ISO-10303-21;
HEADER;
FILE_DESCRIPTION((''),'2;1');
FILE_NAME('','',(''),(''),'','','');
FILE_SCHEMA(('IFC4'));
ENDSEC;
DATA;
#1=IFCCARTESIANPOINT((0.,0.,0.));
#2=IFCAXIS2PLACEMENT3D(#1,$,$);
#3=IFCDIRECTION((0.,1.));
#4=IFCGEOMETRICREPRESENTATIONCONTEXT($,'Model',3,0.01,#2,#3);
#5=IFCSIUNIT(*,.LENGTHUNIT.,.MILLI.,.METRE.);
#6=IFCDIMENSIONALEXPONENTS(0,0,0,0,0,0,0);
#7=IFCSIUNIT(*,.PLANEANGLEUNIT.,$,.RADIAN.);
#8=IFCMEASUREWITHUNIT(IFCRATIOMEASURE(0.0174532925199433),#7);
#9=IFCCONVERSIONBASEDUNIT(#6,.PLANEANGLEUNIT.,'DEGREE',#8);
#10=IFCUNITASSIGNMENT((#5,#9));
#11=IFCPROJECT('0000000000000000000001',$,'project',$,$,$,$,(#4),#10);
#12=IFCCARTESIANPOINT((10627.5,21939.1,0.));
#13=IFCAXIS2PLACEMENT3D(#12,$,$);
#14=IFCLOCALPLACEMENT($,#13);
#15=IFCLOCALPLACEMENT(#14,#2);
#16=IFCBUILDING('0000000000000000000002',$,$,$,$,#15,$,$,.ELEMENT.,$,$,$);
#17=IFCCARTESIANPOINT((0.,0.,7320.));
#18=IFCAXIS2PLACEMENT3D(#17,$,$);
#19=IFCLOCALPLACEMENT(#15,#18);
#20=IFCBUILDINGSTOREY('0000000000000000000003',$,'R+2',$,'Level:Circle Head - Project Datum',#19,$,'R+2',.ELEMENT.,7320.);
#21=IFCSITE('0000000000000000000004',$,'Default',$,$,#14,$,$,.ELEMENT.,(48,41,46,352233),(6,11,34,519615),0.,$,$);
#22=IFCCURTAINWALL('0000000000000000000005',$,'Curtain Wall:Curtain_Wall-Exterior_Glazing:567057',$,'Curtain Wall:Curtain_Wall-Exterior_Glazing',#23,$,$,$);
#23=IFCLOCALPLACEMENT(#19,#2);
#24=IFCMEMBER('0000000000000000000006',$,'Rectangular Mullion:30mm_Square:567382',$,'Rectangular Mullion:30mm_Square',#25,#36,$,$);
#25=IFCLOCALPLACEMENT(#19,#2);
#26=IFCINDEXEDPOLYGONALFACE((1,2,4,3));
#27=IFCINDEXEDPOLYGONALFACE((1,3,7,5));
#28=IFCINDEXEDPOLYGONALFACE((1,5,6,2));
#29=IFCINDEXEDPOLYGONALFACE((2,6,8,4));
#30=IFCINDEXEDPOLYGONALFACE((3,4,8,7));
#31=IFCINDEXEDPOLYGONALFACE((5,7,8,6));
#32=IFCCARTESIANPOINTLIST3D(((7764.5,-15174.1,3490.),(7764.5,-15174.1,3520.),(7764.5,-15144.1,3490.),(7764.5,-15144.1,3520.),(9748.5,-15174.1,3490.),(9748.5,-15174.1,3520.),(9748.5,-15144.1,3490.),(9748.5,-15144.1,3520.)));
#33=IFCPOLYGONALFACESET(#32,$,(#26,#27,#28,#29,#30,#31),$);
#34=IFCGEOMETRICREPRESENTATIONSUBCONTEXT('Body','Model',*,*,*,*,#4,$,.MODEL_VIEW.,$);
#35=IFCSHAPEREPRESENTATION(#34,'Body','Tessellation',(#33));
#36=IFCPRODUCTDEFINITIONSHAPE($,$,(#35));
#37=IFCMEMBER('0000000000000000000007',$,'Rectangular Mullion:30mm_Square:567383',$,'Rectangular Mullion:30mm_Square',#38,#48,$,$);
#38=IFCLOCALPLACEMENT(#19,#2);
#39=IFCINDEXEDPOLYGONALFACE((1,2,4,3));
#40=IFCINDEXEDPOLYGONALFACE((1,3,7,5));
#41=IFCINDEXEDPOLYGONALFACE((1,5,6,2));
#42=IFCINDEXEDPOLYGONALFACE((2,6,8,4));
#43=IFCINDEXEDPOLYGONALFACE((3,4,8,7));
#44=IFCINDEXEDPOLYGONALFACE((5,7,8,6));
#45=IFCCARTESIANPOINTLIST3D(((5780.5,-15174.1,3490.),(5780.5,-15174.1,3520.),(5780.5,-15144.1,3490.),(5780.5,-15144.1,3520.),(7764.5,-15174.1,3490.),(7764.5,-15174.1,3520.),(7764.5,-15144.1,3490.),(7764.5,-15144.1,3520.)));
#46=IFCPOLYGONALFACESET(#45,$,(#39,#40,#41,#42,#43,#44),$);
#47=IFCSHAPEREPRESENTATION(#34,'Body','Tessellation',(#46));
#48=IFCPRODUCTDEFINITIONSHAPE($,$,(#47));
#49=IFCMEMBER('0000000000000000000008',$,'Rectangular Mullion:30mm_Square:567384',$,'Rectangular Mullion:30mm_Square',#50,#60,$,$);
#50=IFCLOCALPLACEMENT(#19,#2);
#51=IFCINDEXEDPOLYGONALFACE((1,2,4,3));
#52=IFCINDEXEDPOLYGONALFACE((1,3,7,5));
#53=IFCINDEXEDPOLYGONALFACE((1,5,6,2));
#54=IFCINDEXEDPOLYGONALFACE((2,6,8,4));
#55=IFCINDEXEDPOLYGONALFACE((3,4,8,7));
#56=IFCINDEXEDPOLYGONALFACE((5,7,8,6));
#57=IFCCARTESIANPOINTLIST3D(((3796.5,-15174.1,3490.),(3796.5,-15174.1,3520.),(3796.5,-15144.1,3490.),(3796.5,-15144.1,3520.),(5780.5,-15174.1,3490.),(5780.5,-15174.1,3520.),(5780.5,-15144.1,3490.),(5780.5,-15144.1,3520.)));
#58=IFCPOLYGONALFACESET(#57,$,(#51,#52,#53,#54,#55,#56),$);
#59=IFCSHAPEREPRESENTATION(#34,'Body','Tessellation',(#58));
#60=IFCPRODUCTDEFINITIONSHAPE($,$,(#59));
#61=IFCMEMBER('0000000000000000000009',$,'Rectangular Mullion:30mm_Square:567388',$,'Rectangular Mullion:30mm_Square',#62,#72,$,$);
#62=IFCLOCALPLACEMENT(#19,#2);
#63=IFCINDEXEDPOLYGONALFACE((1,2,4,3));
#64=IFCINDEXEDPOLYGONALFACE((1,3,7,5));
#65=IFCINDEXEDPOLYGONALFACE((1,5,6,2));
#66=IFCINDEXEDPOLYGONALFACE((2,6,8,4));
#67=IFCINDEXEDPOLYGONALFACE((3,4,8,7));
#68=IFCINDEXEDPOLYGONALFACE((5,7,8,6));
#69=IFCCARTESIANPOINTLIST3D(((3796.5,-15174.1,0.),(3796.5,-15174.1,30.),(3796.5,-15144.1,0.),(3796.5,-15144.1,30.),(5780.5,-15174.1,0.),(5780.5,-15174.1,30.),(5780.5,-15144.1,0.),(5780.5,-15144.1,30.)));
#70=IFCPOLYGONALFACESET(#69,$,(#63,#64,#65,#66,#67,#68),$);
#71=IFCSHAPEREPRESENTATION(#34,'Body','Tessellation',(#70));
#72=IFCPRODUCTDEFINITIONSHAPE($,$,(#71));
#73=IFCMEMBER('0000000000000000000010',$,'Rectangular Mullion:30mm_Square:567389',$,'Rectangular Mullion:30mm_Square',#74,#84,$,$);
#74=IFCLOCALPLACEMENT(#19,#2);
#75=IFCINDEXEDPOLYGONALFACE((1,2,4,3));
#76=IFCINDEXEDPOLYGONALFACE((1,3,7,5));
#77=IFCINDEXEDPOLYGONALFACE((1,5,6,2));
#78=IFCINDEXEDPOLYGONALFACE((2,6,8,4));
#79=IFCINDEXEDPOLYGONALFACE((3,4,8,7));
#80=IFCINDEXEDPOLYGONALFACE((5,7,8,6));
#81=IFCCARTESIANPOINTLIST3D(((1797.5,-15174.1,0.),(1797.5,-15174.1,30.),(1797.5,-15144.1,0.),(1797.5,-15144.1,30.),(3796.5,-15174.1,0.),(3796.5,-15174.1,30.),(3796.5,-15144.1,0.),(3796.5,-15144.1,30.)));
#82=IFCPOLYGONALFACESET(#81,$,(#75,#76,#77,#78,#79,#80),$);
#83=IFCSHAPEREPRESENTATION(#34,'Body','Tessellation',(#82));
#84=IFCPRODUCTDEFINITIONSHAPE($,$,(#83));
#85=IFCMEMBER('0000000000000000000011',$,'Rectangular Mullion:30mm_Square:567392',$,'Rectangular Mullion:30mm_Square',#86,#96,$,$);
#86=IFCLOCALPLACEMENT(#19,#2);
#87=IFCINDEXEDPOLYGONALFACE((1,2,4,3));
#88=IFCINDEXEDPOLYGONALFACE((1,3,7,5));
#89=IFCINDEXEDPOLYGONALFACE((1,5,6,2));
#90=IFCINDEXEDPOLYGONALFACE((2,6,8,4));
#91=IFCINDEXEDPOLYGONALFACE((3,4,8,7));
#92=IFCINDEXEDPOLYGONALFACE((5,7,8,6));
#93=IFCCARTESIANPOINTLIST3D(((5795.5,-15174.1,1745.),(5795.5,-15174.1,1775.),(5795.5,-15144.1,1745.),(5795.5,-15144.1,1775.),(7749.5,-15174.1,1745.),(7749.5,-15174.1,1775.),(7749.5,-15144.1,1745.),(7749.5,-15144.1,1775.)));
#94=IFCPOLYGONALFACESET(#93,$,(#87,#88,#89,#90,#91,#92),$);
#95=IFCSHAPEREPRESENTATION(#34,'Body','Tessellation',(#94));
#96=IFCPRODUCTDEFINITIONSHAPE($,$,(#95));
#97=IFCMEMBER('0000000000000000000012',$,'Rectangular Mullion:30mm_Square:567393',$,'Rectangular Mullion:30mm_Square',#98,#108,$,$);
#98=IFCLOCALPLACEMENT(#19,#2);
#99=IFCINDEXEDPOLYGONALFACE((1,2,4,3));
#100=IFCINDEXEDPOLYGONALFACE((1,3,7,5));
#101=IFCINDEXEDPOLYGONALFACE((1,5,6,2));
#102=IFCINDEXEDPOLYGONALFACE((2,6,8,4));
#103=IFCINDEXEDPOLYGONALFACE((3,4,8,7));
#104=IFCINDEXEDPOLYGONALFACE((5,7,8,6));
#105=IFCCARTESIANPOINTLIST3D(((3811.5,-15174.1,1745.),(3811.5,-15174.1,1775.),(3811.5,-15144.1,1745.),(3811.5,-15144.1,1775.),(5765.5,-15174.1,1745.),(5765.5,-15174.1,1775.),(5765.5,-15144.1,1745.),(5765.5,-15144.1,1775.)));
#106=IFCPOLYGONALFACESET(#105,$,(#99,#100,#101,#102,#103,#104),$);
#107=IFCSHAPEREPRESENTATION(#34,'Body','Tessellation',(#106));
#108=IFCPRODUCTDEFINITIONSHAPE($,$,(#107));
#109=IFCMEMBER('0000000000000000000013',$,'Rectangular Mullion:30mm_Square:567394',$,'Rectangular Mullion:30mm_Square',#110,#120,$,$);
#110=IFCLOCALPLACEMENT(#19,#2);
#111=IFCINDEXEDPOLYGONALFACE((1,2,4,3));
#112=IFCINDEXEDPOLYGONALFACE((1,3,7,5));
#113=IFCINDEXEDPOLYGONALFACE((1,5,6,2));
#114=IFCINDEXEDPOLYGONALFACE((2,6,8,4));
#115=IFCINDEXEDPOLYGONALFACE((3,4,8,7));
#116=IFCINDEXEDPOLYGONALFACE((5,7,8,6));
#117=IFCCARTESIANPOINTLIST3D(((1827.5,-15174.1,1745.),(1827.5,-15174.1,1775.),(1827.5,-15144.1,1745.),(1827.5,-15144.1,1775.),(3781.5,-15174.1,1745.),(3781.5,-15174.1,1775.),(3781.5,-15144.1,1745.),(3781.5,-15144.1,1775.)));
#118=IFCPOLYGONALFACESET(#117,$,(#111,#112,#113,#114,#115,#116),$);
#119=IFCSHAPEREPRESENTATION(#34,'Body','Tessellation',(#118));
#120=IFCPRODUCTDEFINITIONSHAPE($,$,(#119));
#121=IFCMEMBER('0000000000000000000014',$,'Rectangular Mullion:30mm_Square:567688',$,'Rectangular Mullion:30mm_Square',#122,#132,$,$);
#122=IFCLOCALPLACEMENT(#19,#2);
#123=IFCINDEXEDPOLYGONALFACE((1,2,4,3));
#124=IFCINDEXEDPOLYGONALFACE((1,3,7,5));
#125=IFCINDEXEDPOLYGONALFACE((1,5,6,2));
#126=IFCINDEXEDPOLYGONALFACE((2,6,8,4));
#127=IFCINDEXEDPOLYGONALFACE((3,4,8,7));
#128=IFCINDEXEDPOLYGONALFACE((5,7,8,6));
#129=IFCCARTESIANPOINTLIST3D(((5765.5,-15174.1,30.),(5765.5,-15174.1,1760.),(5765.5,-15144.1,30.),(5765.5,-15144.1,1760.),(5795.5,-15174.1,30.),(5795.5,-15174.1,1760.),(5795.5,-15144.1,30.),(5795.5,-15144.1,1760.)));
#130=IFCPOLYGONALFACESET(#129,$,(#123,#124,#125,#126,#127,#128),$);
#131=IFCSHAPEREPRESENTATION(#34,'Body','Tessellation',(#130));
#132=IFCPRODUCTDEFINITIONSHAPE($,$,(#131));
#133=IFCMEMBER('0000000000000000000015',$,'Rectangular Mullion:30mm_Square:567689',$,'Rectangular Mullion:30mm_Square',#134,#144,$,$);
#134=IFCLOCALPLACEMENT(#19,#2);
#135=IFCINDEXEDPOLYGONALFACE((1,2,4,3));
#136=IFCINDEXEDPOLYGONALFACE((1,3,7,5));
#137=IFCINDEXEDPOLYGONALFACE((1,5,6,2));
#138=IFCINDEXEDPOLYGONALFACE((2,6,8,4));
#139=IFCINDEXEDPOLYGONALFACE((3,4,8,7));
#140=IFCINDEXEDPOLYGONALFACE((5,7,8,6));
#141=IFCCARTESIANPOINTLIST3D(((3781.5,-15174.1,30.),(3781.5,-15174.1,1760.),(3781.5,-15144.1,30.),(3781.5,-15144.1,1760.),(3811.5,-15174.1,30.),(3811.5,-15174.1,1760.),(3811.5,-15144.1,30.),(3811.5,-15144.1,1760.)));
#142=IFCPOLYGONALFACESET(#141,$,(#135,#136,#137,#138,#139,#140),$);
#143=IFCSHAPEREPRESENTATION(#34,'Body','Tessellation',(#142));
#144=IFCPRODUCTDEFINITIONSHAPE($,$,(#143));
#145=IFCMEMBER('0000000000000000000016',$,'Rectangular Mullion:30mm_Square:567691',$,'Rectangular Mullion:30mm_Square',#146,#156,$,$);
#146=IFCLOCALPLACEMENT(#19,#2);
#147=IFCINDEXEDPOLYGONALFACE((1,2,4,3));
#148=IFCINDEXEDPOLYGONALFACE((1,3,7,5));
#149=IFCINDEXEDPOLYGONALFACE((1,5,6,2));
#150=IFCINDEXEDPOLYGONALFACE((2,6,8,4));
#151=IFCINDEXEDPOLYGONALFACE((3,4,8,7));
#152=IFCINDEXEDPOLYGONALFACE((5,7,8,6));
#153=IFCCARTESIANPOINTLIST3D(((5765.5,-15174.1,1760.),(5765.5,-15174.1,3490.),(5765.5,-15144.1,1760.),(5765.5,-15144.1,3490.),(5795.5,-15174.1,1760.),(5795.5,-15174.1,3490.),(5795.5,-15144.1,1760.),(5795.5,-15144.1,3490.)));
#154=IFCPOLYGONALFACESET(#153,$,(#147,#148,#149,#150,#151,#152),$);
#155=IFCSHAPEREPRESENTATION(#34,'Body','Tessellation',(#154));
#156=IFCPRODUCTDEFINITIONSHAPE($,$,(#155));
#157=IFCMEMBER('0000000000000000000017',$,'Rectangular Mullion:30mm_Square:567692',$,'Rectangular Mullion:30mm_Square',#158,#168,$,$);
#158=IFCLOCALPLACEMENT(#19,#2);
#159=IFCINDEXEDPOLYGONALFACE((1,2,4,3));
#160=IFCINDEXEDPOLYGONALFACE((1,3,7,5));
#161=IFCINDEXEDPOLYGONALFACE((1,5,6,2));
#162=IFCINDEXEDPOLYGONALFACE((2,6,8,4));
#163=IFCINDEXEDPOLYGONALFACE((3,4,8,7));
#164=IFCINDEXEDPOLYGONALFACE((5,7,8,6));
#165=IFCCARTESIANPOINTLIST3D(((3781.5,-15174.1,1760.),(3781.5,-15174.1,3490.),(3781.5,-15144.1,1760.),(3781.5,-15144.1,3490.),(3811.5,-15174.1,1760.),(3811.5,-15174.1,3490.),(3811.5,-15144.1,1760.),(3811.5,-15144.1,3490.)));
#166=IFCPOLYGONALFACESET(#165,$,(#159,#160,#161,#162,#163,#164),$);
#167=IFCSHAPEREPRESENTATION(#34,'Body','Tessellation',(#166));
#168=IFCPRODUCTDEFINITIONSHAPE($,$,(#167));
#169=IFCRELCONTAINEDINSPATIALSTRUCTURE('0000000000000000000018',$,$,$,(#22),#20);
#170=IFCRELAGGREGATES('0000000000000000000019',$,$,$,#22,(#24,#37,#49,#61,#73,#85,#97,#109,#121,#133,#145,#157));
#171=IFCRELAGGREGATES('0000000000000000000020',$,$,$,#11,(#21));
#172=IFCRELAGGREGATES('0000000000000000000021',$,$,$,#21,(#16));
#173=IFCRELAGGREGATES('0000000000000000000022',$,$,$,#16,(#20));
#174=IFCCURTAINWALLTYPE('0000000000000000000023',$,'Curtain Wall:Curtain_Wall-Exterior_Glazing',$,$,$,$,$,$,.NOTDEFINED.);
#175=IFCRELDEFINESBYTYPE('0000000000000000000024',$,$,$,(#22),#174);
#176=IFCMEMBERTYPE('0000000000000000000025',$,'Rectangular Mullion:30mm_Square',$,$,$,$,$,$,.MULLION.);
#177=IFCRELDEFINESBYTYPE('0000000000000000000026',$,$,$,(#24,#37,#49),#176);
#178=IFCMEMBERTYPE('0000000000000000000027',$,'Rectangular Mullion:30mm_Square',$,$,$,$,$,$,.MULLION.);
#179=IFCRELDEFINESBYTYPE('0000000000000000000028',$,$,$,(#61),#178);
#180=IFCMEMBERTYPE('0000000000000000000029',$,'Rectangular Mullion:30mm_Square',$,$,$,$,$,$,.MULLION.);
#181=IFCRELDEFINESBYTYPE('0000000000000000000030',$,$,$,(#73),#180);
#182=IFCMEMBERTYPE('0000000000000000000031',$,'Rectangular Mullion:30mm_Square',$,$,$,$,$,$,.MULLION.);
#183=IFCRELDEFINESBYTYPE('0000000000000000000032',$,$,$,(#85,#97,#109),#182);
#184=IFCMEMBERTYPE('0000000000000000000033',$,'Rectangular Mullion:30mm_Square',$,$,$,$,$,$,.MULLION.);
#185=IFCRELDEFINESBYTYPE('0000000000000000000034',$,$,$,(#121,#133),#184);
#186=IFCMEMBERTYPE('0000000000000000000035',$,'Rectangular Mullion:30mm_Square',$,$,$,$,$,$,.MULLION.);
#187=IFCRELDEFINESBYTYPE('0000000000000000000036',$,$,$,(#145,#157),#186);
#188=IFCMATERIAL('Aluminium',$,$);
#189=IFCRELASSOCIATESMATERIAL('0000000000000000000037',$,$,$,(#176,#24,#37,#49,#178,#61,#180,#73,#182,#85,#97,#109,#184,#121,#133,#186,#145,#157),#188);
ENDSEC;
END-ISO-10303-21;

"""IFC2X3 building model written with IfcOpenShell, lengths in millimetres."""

from ifc_helpers import new_model, entity, si_unit, converted_unit, direction, frame, origin, origin_2d_with_axis, place, context, subcontext, project, spatial, rectangle, extrude, source, transform, mapped, material, type_object, type_shapes, element, aggregate, save


model = new_model("IFC2X3")

# Units and contexts
model_context = context("Model", 3, precision=0.01, world=origin(), true_north=direction((0.0, 1.0)))
body_context = subcontext(model_context, "Body", "Model", "MODEL_VIEW")
ifc_project = project(units=[si_unit("LENGTHUNIT", "METRE", prefix="MILLI"), converted_unit("PLANEANGLEUNIT", "DEGREE", entity("IfcRatioMeasure", 0.0174532925199433), si_unit("PLANEANGLEUNIT", "RADIAN"), dimensions=[0, 0, 0, 0, 0, 0, 0])], contexts=[model_context])

# Site, building, storey
site_placement = place(None, frame((10627.5, 21939.1, 0.0)))
site = spatial("IfcSite", under=ifc_project, at=site_placement, Name="Default", CompositionType="ELEMENT", RefLatitude=(48, 41, 46, 352233), RefLongitude=(6, 11, 34, 519615), RefElevation=0.0)
building_placement = place(site_placement, origin())
building = spatial("IfcBuilding", under=site, at=building_placement, CompositionType="ELEMENT")
storey_placement = place(building_placement, frame((0.0, 0.0, 7320.0)))
storey = spatial("IfcBuildingStorey", under=building, at=storey_placement, Name="R+2", ObjectType="Level:Circle Head - Project Datum", LongName="R+2", CompositionType="ELEMENT", Elevation=7320.0)

# Curtain wall, members
curtain_wall_type = type_object("IfcCurtainWallType", Name="Curtain Wall:Curtain_Wall-Exterior_Glazing", PredefinedType="NOTDEFINED")
curtain_wall_placement = place(storey_placement, frame((0.0, 0.0, -7320.0)))
curtain_wall = element("IfcCurtainWall", 1, at=curtain_wall_placement, inside=storey, type_object=curtain_wall_type, Name="Curtain Wall:Curtain_Wall-Exterior_Glazing:567057", ObjectType="Curtain Wall:Curtain_Wall-Exterior_Glazing")
ifc_material_1 = material(Name="Aluminium")
member_type_1 = type_object("IfcMemberType", Name="Rectangular Mullion:30mm_Square", PredefinedType="MULLION", material=ifc_material_1)
shared_shape_1 = source(origin(), body_context, "Body", "SweptSolid", [
    extrude(rectangle(XDim=30.0, YDim=30.0, at=origin_2d_with_axis()), frame((-15.0, 0.0, -1984.0), z_axis=(0.0, 0.0, 1.0), x_axis=(0.0, -1.0, 0.0)), (0.0, 0.0, 1.0), 1984.0),
])
type_shapes(member_type_1, [shared_shape_1])
member_1_placement = place(storey_placement, frame((7764.5, -15159.1, 3520.0), z_axis=(-1.0, 0.0, 0.0), x_axis=(0.0, 0.0, 1.0)))
member_1 = element("IfcMember", 2, at=member_1_placement, type_object=member_type_1, material=ifc_material_1, Name="Rectangular Mullion:30mm_Square:567382", ObjectType="Rectangular Mullion:30mm_Square", context=body_context, shape_type="MappedRepresentation", body=[
    mapped(shared_shape_1, transform((0.0, 0.0, 0.0), scale=1.0)),
])
member_2_placement = place(storey_placement, frame((5780.5, -15159.1, 3520.0), z_axis=(-1.0, 0.0, 0.0), x_axis=(0.0, 0.0, 1.0)))
member_2 = element("IfcMember", 3, at=member_2_placement, type_object=member_type_1, material=ifc_material_1, Name="Rectangular Mullion:30mm_Square:567383", ObjectType="Rectangular Mullion:30mm_Square", context=body_context, shape_type="MappedRepresentation", body=[
    mapped(shared_shape_1, transform((0.0, 0.0, 0.0), scale=1.0)),
])
member_3_placement = place(storey_placement, frame((3796.5, -15159.1, 3520.0), z_axis=(-1.0, 0.0, 0.0), x_axis=(0.0, 0.0, 1.0)))
member_3 = element("IfcMember", 4, at=member_3_placement, type_object=member_type_1, material=ifc_material_1, Name="Rectangular Mullion:30mm_Square:567384", ObjectType="Rectangular Mullion:30mm_Square", context=body_context, shape_type="MappedRepresentation", body=[
    mapped(shared_shape_1, transform((0.0, 0.0, 0.0), scale=1.0)),
])
member_type_2 = type_object("IfcMemberType", Name="Rectangular Mullion:30mm_Square", PredefinedType="MULLION", material=ifc_material_1)
shared_shape_2 = source(origin(), body_context, "Body", "SweptSolid", [
    extrude(rectangle(XDim=30.0, YDim=30.0, at=origin_2d_with_axis()), frame((-15.0, 0.0, -1984.0), z_axis=(0.0, 0.0, 1.0), x_axis=(0.0, -1.0, 0.0)), (0.0, 0.0, 1.0), 1984.0),
])
type_shapes(member_type_2, [shared_shape_2])
member_4_placement = place(storey_placement, frame((5780.5, -15159.1, 0.0), z_axis=(1.0, 0.0, 0.0), x_axis=(0.0, 0.0, -1.0)))
member_4 = element("IfcMember", 5, at=member_4_placement, type_object=member_type_2, material=ifc_material_1, Name="Rectangular Mullion:30mm_Square:567388", ObjectType="Rectangular Mullion:30mm_Square", context=body_context, shape_type="MappedRepresentation", body=[
    mapped(shared_shape_2, transform((0.0, 0.0, 0.0), scale=1.0)),
])
member_type_3 = type_object("IfcMemberType", Name="Rectangular Mullion:30mm_Square", PredefinedType="MULLION", material=ifc_material_1)
shared_shape_3 = source(origin(), body_context, "Body", "SweptSolid", [
    extrude(rectangle(XDim=30.0, YDim=30.0, at=origin_2d_with_axis()), frame((-15.0, 0.0, -1999.0), z_axis=(0.0, 0.0, 1.0), x_axis=(0.0, -1.0, 0.0)), (0.0, 0.0, 1.0), 1999.0),
])
type_shapes(member_type_3, [shared_shape_3])
member_5_placement = place(storey_placement, frame((3796.5, -15159.1, 0.0), z_axis=(1.0, 0.0, 0.0), x_axis=(0.0, 0.0, -1.0)))
member_5 = element("IfcMember", 6, at=member_5_placement, type_object=member_type_3, material=ifc_material_1, Name="Rectangular Mullion:30mm_Square:567389", ObjectType="Rectangular Mullion:30mm_Square", context=body_context, shape_type="MappedRepresentation", body=[
    mapped(shared_shape_3, transform((0.0, 0.0, 0.0), scale=1.0)),
])
member_type_4 = type_object("IfcMemberType", Name="Rectangular Mullion:30mm_Square", PredefinedType="MULLION", material=ifc_material_1)
shared_shape_4 = source(origin(), body_context, "Body", "SweptSolid", [
    extrude(rectangle(XDim=30.0, YDim=30.0, at=origin_2d_with_axis()), frame((0.0, 0.0, -1954.0), z_axis=(0.0, 0.0, 1.0), x_axis=(0.0, -1.0, 0.0)), (0.0, 0.0, 1.0), 1954.0),
])
type_shapes(member_type_4, [shared_shape_4])
member_6_placement = place(storey_placement, frame((5795.5, -15159.1, 1760.0), z_axis=(-1.0, 0.0, 0.0), x_axis=(0.0, 0.0, 1.0)))
member_6 = element("IfcMember", 7, at=member_6_placement, type_object=member_type_4, material=ifc_material_1, Name="Rectangular Mullion:30mm_Square:567392", ObjectType="Rectangular Mullion:30mm_Square", context=body_context, shape_type="MappedRepresentation", body=[
    mapped(shared_shape_4, transform((0.0, 0.0, 0.0), scale=1.0)),
])
member_7_placement = place(storey_placement, frame((3811.5, -15159.1, 1760.0), z_axis=(-1.0, 0.0, 0.0), x_axis=(0.0, 0.0, 1.0)))
member_7 = element("IfcMember", 8, at=member_7_placement, type_object=member_type_4, material=ifc_material_1, Name="Rectangular Mullion:30mm_Square:567393", ObjectType="Rectangular Mullion:30mm_Square", context=body_context, shape_type="MappedRepresentation", body=[
    mapped(shared_shape_4, transform((0.0, 0.0, 0.0), scale=1.0)),
])
member_8_placement = place(storey_placement, frame((1827.5, -15159.1, 1760.0), z_axis=(-1.0, 0.0, 0.0), x_axis=(0.0, 0.0, 1.0)))
member_8 = element("IfcMember", 9, at=member_8_placement, type_object=member_type_4, material=ifc_material_1, Name="Rectangular Mullion:30mm_Square:567394", ObjectType="Rectangular Mullion:30mm_Square", context=body_context, shape_type="MappedRepresentation", body=[
    mapped(shared_shape_4, transform((0.0, 0.0, 0.0), scale=1.0)),
])
member_type_5 = type_object("IfcMemberType", Name="Rectangular Mullion:30mm_Square", PredefinedType="MULLION", material=ifc_material_1)
shared_shape_5 = source(origin(), body_context, "Body", "SweptSolid", [
    extrude(rectangle(XDim=30.0, YDim=30.0, at=origin_2d_with_axis()), frame((0.0, 0.0, -1730.0), z_axis=(0.0, 0.0, 1.0), x_axis=(0.0, -1.0, 0.0)), (0.0, 0.0, 1.0), 1730.0),
])
type_shapes(member_type_5, [shared_shape_5])
member_9_placement = place(storey_placement, frame((5780.5, -15159.1, 30.0), z_axis=(0.0, 0.0, -1.0), x_axis=(-1.0, 0.0, 0.0)))
member_9 = element("IfcMember", 10, at=member_9_placement, type_object=member_type_5, material=ifc_material_1, Name="Rectangular Mullion:30mm_Square:567688", ObjectType="Rectangular Mullion:30mm_Square", context=body_context, shape_type="MappedRepresentation", body=[
    mapped(shared_shape_5, transform((0.0, 0.0, 0.0), scale=1.0)),
])
member_10_placement = place(storey_placement, frame((3796.5, -15159.1, 30.0), z_axis=(0.0, 0.0, -1.0), x_axis=(-1.0, 0.0, 0.0)))
member_10 = element("IfcMember", 11, at=member_10_placement, type_object=member_type_5, material=ifc_material_1, Name="Rectangular Mullion:30mm_Square:567689", ObjectType="Rectangular Mullion:30mm_Square", context=body_context, shape_type="MappedRepresentation", body=[
    mapped(shared_shape_5, transform((0.0, 0.0, 0.0), scale=1.0)),
])
member_type_6 = type_object("IfcMemberType", Name="Rectangular Mullion:30mm_Square", PredefinedType="MULLION", material=ifc_material_1)
shared_shape_6 = source(origin(), body_context, "Body", "SweptSolid", [
    extrude(rectangle(XDim=30.0, YDim=30.0, at=origin_2d_with_axis()), frame((0.0, 0.0, -1730.0), z_axis=(0.0, 0.0, 1.0), x_axis=(0.0, -1.0, 0.0)), (0.0, 0.0, 1.0), 1730.0),
])
type_shapes(member_type_6, [shared_shape_6])
member_11_placement = place(storey_placement, frame((5780.5, -15159.1, 1760.0), z_axis=(0.0, 0.0, -1.0), x_axis=(-1.0, 0.0, 0.0)))
member_11 = element("IfcMember", 12, at=member_11_placement, type_object=member_type_6, material=ifc_material_1, Name="Rectangular Mullion:30mm_Square:567691", ObjectType="Rectangular Mullion:30mm_Square", context=body_context, shape_type="MappedRepresentation", body=[
    mapped(shared_shape_6, transform((0.0, 0.0, 0.0), scale=1.0)),
])
member_12_placement = place(storey_placement, frame((3796.5, -15159.1, 1760.0), z_axis=(0.0, 0.0, -1.0), x_axis=(-1.0, 0.0, 0.0)))
member_12 = element("IfcMember", 13, at=member_12_placement, type_object=member_type_6, material=ifc_material_1, Name="Rectangular Mullion:30mm_Square:567692", ObjectType="Rectangular Mullion:30mm_Square", context=body_context, shape_type="MappedRepresentation", body=[
    mapped(shared_shape_6, transform((0.0, 0.0, 0.0), scale=1.0)),
])
aggregate(curtain_wall, [member_1, member_2, member_3, member_4, member_5, member_6, member_7, member_8, member_9, member_10, member_11, member_12])

save(model, "model.ifc")
